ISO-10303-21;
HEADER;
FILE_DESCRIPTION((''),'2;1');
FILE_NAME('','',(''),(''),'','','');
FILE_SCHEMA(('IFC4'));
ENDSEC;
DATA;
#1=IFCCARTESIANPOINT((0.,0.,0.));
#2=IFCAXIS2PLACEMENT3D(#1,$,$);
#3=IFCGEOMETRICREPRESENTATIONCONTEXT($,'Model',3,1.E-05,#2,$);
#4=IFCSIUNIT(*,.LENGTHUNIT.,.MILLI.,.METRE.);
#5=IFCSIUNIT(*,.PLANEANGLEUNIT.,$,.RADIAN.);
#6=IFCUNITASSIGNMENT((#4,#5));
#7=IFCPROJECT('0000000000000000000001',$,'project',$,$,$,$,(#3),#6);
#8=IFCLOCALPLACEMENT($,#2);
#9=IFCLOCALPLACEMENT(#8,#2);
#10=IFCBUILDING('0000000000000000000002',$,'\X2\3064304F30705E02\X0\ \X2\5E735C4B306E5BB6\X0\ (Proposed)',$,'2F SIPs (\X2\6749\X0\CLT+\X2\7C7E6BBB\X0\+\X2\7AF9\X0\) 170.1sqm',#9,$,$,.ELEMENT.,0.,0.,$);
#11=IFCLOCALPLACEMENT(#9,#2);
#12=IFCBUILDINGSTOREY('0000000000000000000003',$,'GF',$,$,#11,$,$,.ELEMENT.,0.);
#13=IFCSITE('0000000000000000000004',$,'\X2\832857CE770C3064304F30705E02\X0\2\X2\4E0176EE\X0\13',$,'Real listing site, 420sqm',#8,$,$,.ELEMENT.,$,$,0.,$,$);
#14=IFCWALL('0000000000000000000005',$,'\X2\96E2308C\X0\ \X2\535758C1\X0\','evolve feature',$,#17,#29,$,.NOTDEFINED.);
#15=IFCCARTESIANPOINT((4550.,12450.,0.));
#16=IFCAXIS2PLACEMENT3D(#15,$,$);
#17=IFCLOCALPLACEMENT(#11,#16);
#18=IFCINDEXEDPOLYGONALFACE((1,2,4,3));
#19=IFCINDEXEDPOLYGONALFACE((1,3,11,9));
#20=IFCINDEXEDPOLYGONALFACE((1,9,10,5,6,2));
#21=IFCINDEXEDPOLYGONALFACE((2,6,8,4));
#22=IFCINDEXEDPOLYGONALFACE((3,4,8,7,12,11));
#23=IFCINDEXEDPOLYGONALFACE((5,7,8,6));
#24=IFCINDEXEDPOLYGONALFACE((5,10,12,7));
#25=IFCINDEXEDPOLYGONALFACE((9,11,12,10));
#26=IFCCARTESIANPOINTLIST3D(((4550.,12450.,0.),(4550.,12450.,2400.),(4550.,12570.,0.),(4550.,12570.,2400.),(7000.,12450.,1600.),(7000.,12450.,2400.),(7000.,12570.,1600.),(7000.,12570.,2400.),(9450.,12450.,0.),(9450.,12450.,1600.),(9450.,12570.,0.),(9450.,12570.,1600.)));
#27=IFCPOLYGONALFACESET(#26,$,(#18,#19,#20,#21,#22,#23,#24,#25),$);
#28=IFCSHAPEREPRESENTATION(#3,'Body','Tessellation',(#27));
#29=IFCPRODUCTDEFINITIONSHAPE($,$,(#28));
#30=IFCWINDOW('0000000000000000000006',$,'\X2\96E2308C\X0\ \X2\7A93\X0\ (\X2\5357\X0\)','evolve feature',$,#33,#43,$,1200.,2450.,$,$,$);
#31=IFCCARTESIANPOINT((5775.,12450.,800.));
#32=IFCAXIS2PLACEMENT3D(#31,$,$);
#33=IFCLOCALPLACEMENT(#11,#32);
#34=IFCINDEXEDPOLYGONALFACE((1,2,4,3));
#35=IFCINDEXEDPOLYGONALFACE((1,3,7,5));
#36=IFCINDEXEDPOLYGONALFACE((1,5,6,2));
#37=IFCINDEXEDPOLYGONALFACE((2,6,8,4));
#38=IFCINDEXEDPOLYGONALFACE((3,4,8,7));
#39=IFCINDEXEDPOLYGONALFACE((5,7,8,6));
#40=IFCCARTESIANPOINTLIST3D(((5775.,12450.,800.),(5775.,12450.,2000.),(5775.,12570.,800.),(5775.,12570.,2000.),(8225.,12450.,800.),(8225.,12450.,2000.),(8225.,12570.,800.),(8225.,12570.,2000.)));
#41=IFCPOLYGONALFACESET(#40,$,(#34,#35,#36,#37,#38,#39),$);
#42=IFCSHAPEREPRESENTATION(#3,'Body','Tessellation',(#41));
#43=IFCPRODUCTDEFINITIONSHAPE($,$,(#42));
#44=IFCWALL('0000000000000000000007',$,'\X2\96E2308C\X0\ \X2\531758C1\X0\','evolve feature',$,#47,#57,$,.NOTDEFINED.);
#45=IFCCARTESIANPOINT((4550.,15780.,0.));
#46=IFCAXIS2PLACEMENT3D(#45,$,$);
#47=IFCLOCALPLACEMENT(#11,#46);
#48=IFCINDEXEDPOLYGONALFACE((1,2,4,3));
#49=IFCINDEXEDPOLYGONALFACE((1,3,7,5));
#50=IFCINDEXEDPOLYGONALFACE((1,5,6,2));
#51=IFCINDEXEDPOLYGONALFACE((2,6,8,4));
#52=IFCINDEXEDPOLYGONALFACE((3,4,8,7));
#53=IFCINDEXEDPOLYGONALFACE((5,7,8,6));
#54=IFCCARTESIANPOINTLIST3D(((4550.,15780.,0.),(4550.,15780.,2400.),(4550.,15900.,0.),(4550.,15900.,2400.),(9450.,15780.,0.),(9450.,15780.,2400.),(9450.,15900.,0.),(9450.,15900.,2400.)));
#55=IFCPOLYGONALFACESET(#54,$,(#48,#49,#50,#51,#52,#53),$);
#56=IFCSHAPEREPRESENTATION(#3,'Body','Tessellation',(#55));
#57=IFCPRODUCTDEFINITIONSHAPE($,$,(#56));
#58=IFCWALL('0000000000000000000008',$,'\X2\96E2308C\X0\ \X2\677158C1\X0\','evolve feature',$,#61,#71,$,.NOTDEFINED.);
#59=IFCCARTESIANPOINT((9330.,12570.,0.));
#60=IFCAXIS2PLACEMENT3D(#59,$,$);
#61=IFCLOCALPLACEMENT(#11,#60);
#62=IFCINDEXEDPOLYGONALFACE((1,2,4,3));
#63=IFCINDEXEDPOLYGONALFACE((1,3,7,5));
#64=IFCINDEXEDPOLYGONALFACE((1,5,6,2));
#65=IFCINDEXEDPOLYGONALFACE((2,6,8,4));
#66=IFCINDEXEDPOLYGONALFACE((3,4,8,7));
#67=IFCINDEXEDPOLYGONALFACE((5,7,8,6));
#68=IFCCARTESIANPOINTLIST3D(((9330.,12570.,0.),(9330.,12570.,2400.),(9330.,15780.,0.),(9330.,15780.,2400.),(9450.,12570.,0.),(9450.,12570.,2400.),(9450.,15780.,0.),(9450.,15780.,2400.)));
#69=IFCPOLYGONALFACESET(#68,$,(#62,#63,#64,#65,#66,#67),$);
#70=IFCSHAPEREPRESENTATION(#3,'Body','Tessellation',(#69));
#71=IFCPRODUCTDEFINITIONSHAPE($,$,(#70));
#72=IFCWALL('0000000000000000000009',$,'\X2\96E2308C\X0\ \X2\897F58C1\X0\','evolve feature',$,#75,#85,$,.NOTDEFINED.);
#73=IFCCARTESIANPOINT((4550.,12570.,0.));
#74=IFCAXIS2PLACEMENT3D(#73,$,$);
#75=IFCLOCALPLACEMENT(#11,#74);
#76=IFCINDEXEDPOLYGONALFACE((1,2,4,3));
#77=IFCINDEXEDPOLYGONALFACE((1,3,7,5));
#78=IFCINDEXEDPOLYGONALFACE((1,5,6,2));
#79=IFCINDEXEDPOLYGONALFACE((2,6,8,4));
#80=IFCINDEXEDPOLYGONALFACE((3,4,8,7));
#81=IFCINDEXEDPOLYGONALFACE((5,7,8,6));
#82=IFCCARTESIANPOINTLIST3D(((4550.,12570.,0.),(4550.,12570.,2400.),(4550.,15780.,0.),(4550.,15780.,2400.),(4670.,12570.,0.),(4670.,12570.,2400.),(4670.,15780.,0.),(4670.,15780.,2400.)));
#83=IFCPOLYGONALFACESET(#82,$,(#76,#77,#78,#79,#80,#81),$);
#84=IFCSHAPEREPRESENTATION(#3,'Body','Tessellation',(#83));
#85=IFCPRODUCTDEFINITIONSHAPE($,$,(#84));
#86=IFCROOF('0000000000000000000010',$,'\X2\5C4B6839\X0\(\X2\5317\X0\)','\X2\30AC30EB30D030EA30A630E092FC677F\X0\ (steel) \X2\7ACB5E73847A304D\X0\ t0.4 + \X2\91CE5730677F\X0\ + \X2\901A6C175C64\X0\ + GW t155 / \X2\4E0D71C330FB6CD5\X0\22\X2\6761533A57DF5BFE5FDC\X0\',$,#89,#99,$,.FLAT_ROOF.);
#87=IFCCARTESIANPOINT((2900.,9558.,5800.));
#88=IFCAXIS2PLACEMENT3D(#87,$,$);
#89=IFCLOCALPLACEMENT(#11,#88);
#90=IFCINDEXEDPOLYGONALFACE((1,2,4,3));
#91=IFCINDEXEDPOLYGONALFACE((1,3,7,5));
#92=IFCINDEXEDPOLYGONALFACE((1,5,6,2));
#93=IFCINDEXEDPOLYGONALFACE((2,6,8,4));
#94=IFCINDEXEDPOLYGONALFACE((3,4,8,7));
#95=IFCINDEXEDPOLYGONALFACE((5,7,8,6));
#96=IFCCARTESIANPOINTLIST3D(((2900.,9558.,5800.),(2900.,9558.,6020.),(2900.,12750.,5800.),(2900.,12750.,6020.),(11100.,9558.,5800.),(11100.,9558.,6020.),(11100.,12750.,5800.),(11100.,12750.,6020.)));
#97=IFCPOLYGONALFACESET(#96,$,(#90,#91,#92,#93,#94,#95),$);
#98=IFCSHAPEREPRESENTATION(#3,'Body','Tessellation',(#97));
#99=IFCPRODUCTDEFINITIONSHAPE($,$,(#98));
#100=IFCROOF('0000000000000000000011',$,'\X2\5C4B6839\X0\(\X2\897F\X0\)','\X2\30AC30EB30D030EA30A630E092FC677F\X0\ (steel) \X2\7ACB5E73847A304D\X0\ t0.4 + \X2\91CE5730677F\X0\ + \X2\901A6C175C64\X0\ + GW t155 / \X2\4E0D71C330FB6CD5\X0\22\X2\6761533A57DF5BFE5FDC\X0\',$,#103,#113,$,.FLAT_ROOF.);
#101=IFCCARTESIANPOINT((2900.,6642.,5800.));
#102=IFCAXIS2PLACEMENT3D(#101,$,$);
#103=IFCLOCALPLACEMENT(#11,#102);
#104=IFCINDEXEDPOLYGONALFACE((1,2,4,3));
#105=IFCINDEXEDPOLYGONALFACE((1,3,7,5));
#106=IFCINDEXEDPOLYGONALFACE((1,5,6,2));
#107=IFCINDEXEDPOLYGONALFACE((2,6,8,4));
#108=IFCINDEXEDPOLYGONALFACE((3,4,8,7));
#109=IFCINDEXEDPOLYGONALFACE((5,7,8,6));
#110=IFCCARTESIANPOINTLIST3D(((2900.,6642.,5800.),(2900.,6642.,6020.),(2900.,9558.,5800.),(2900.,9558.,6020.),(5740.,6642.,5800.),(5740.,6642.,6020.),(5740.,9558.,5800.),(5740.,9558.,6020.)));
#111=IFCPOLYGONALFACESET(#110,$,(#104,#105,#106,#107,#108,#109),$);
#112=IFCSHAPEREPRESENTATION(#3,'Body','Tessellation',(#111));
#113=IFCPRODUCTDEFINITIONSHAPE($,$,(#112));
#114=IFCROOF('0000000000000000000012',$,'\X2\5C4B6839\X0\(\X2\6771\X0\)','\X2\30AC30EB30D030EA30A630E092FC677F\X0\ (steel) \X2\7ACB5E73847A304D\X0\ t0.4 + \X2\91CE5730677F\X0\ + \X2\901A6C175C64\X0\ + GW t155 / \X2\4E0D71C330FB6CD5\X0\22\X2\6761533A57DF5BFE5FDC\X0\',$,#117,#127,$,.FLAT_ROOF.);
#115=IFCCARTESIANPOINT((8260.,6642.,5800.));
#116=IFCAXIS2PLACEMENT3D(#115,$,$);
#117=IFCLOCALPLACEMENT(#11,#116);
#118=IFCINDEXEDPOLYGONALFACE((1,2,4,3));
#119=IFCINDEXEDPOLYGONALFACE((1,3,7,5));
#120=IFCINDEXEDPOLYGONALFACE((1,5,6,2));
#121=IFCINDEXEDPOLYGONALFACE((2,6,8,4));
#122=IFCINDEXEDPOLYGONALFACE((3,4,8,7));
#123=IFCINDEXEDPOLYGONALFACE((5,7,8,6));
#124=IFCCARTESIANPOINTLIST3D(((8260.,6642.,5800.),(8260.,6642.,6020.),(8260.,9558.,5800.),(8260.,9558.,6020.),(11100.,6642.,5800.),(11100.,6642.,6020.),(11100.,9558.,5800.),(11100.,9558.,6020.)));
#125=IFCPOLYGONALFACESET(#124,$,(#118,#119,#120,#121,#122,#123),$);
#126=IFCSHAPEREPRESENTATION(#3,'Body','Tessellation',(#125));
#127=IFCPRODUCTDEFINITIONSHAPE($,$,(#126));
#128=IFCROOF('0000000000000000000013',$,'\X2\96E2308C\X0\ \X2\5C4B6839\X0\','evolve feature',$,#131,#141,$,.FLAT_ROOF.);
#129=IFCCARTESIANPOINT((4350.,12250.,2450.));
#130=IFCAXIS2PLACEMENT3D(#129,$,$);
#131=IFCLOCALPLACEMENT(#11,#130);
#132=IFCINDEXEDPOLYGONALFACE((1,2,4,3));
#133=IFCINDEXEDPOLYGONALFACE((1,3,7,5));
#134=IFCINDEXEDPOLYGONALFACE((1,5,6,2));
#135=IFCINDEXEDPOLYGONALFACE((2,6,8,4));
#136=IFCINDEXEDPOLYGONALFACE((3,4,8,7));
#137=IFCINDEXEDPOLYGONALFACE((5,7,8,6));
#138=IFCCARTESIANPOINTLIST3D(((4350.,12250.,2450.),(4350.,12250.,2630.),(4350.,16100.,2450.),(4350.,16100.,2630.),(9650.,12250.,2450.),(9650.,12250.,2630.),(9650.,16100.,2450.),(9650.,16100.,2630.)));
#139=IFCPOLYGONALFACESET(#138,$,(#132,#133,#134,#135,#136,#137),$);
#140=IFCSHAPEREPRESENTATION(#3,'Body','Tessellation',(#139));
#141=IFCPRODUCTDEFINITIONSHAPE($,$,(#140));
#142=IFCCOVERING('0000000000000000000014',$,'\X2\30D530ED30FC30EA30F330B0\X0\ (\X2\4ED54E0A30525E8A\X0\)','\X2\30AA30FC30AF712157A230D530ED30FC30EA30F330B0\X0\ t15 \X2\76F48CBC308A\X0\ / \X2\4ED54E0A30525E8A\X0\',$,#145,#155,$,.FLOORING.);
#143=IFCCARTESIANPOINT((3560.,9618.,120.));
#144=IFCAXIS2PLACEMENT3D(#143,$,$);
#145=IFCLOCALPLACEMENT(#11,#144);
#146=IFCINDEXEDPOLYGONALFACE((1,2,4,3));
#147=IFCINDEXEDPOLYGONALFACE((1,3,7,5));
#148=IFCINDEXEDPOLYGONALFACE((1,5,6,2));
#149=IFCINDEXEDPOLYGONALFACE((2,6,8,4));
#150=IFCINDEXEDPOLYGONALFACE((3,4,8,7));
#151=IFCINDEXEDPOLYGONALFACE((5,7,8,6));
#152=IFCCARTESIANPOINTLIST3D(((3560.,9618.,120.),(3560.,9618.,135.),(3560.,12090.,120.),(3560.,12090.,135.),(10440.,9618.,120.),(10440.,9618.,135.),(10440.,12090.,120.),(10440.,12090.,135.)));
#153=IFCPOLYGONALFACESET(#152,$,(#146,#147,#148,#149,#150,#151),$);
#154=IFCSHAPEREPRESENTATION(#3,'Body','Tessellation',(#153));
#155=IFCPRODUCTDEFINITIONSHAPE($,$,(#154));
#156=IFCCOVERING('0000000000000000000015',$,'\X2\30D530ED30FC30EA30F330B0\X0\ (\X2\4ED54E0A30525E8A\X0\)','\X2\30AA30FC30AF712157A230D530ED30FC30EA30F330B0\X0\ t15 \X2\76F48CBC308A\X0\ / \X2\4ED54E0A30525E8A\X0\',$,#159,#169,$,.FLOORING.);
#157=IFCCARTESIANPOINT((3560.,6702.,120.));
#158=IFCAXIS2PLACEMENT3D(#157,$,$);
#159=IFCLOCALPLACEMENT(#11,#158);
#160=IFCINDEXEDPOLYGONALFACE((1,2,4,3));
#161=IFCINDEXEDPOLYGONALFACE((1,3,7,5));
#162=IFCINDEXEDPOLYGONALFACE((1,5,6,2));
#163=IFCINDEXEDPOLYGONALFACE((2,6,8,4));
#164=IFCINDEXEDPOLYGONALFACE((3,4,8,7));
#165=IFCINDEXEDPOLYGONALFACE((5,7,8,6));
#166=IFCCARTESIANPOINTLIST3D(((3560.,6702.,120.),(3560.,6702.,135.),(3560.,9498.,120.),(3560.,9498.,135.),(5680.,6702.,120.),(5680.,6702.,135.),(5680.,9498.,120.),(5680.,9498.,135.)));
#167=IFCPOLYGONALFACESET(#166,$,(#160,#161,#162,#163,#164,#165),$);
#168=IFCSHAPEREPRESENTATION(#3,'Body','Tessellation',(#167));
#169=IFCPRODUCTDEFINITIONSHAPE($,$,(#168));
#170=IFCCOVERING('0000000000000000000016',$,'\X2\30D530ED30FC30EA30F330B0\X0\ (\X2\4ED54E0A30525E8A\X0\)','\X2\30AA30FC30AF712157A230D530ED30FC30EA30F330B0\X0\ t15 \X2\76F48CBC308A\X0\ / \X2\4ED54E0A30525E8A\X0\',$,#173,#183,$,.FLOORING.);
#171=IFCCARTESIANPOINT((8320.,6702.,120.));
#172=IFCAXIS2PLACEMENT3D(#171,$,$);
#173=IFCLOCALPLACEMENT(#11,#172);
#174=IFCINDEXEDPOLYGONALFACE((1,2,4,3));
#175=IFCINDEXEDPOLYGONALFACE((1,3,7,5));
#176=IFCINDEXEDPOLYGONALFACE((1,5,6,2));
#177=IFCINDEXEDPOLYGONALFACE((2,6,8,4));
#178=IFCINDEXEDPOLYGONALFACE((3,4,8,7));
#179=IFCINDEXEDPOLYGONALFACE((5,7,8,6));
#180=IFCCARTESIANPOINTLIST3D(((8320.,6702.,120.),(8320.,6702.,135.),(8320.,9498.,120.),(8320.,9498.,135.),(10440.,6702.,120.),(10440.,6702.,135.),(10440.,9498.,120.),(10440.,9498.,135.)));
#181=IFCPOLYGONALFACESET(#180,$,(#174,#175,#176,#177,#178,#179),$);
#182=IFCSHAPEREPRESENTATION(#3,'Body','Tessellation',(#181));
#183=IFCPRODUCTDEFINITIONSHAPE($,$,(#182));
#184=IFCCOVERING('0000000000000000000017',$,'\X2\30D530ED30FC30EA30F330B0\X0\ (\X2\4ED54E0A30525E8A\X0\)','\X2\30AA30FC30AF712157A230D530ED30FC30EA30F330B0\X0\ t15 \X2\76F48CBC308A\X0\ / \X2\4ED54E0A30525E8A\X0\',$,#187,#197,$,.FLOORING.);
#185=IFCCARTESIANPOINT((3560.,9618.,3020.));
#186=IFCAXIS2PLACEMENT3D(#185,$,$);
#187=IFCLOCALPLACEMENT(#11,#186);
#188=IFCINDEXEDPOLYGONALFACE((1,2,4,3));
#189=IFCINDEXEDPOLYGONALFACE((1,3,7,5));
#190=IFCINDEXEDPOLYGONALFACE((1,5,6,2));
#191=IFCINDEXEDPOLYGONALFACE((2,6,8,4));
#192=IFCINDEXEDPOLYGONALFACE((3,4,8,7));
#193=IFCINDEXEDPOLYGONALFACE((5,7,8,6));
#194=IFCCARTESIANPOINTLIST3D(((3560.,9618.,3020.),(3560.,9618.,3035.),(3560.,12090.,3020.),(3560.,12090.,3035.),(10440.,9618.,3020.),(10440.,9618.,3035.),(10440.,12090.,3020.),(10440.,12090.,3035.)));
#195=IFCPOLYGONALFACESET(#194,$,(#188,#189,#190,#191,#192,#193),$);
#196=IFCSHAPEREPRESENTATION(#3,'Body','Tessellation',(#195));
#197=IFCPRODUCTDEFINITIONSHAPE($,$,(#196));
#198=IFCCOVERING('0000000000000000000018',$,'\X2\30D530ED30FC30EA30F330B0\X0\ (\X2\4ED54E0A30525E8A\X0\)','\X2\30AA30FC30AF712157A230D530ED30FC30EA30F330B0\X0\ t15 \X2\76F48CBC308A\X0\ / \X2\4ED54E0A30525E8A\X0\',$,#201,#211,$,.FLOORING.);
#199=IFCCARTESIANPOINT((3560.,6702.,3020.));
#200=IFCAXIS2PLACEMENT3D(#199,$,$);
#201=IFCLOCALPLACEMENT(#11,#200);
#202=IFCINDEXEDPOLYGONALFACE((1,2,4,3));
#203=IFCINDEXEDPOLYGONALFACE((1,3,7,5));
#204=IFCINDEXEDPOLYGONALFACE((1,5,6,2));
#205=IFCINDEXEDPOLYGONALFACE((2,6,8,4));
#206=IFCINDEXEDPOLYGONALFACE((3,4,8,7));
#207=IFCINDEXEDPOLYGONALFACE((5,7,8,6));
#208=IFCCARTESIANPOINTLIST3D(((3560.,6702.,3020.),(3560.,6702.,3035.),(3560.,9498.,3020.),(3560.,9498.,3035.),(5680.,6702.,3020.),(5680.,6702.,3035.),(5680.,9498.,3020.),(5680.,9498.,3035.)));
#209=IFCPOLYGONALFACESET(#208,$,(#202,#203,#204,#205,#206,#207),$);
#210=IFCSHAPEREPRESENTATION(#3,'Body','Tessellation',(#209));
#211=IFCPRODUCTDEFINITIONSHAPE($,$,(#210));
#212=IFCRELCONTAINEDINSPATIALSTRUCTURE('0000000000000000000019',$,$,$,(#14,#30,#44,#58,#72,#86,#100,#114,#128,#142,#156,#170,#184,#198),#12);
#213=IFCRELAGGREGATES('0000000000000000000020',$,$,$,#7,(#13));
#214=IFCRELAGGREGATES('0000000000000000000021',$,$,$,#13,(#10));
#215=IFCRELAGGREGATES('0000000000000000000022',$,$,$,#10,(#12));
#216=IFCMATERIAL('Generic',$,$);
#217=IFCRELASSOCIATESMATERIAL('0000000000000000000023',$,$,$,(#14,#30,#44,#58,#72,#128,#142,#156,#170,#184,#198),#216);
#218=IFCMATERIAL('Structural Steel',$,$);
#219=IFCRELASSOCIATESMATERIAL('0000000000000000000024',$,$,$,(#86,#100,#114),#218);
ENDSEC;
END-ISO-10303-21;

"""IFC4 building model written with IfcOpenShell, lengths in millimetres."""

from ifc_helpers import new_model, si_unit, frame, frame_2d, origin, place, context, project, spatial, rectangle, extrude, material, element, fill, save


model = new_model("IFC4")

# Units and contexts
model_context = context("Model", 3, precision=1e-05, world=origin())
ifc_project = project(units=[si_unit("LENGTHUNIT", "METRE", prefix="MILLI"), si_unit("PLANEANGLEUNIT", "RADIAN")], contexts=[model_context])

# Site, building, storey
site_placement = place(None, origin())
site = spatial("IfcSite", under=ifc_project, at=site_placement, Name="茨城県つくば市2丁目13", ObjectType="Real listing site, 420sqm", CompositionType="ELEMENT", RefElevation=0.0)
building_placement = place(site_placement, origin())
building = spatial("IfcBuilding", under=site, at=building_placement, Name="つくば市 平屋の家 (Proposed)", ObjectType="2F SIPs (杉CLT+籾殻+竹) 170.1sqm", CompositionType="ELEMENT", ElevationOfRefHeight=0.0, ElevationOfTerrain=0.0)
storey_placement = place(building_placement, origin())
storey = spatial("IfcBuildingStorey", under=building, at=storey_placement, Name="GF", CompositionType="ELEMENT", Elevation=0.0)

# Shared definitions
ifc_material_1 = material(Name="Generic")

# Wall, opening, window
wall_1_placement = place(storey_placement, frame((4550.0, 12450.0, 0.0)))
wall_1 = element("IfcWall", 1, at=wall_1_placement, inside=storey, material=ifc_material_1, Name="離れ 南壁", Description="evolve feature", PredefinedType="NOTDEFINED", context=model_context, shape_type="SweptSolid", body=[
    extrude(rectangle(XDim=4900.0, YDim=120.0, at=frame_2d((2450.0, 60.0))), frame((4550.0, 12450.0, 0.0)), (0.0, 0.0, 1.0), 2400.0),
])
opening_1_placement = place(storey_placement, frame((5775.0, 12450.0, 800.0)))
opening_1 = element("IfcOpeningElement", 2, at=opening_1_placement, cuts=wall_1, PredefinedType="NOTDEFINED", context=model_context, shape_type="SweptSolid", body=[
    extrude(rectangle(XDim=2450.0, YDim=120.0, at=frame_2d((1225.0, 60.0))), frame((5775.0, 12450.0, 800.0)), (0.0, 0.0, 1.0), 1200.0),
])
window_1_placement = place(storey_placement, frame((5775.0, 12450.0, 800.0)))
window_1 = element("IfcWindow", 3, at=window_1_placement, inside=storey, material=ifc_material_1, Name="離れ 窓 (南)", Description="evolve feature", OverallHeight=1200.0, OverallWidth=2450.0, context=model_context, shape_type="SweptSolid", body=[
    extrude(rectangle(XDim=2450.0, YDim=120.0, at=frame_2d((1225.0, 60.0))), frame((5775.0, 12450.0, 800.0)), (0.0, 0.0, 1.0), 1200.0),
])
fill(opening_1, window_1)

# Walls
wall_2_placement = place(storey_placement, frame((4550.0, 15780.0, 0.0)))
element("IfcWall", 4, at=wall_2_placement, inside=storey, material=ifc_material_1, Name="離れ 北壁", Description="evolve feature", PredefinedType="NOTDEFINED", context=model_context, shape_type="SweptSolid", body=[
    extrude(rectangle(XDim=4900.0, YDim=120.0, at=frame_2d((2450.0, 60.0))), frame((4550.0, 15780.0, 0.0)), (0.0, 0.0, 1.0), 2400.0),
])
wall_3_placement = place(storey_placement, frame((9330.0, 12570.0, 0.0)))
element("IfcWall", 5, at=wall_3_placement, inside=storey, material=ifc_material_1, Name="離れ 東壁", Description="evolve feature", PredefinedType="NOTDEFINED", context=model_context, shape_type="SweptSolid", body=[
    extrude(rectangle(XDim=120.0, YDim=3210.0, at=frame_2d((60.0, 1605.0))), frame((9330.0, 12570.0, 0.0)), (0.0, 0.0, 1.0), 2400.0),
])
wall_4_placement = place(storey_placement, frame((4550.0, 12570.0, 0.0)))
element("IfcWall", 6, at=wall_4_placement, inside=storey, material=ifc_material_1, Name="離れ 西壁", Description="evolve feature", PredefinedType="NOTDEFINED", context=model_context, shape_type="SweptSolid", body=[
    extrude(rectangle(XDim=120.0, YDim=3210.0, at=frame_2d((60.0, 1605.0))), frame((4550.0, 12570.0, 0.0)), (0.0, 0.0, 1.0), 2400.0),
])

# Roofs
ifc_material_2 = material(Name="Structural Steel")
for number, where, name in (
    (7, (2900.0, 9558.0, 5800.0), "屋根(北)"),
):
    element("IfcRoof", number, at=place(storey_placement, frame(where)), inside=storey, material=ifc_material_2, Name=name, Description="ガルバリウム鋼板 (steel) 立平葺き t0.4 + 野地板 + 通気層 + GW t155 / 不燃・法22条区域対応", PredefinedType="FLAT_ROOF", context=model_context, shape_type="SweptSolid", body=[
        extrude(rectangle(XDim=8200.0, YDim=3192.0, at=frame_2d((4100.0, 1596.0))), frame((2900.0, 9558.0, 5800.0)), (0.0, 0.0, 1.0), 220.0),
    ])
roof_1_placement = place(storey_placement, frame((2900.0, 6642.0, 5800.0)))
element("IfcRoof", 8, at=roof_1_placement, inside=storey, material=ifc_material_2, Name="屋根(西)", Description="ガルバリウム鋼板 (steel) 立平葺き t0.4 + 野地板 + 通気層 + GW t155 / 不燃・法22条区域対応", PredefinedType="FLAT_ROOF", context=model_context, shape_type="SweptSolid", body=[
    extrude(rectangle(XDim=2840.0, YDim=2916.0, at=frame_2d((1420.0, 1458.0))), frame((2900.0, 6642.0, 5800.0)), (0.0, 0.0, 1.0), 220.0),
])
roof_2_placement = place(storey_placement, frame((8260.0, 6642.0, 5800.0)))
element("IfcRoof", 9, at=roof_2_placement, inside=storey, material=ifc_material_2, Name="屋根(東)", Description="ガルバリウム鋼板 (steel) 立平葺き t0.4 + 野地板 + 通気層 + GW t155 / 不燃・法22条区域対応", PredefinedType="FLAT_ROOF", context=model_context, shape_type="SweptSolid", body=[
    extrude(rectangle(XDim=2840.0, YDim=2916.0, at=frame_2d((1420.0, 1458.0))), frame((8260.0, 6642.0, 5800.0)), (0.0, 0.0, 1.0), 220.0),
])
roof_3_placement = place(storey_placement, frame((4350.0, 12250.0, 2450.0)))
element("IfcRoof", 10, at=roof_3_placement, inside=storey, material=ifc_material_1, Name="離れ 屋根", Description="evolve feature", PredefinedType="FLAT_ROOF", context=model_context, shape_type="SweptSolid", body=[
    extrude(rectangle(XDim=5300.0, YDim=3850.0, at=frame_2d((2650.0, 1925.0))), frame((4350.0, 12250.0, 2450.0)), (0.0, 0.0, 1.0), 180.0),
])

# Coverings
covering_1_placement = place(storey_placement, frame((3560.0, 9618.0, 120.0)))
element("IfcCovering", 11, at=covering_1_placement, inside=storey, material=ifc_material_1, Name="フローリング (仕上げ床)", Description="オーク無垢フローリング t15 直貼り / 仕上げ床", PredefinedType="FLOORING", context=model_context, shape_type="SweptSolid", body=[
    extrude(rectangle(XDim=6880.0, YDim=2472.0, at=frame_2d((3440.0, 1236.0))), frame((3560.0, 9618.0, 120.0)), (0.0, 0.0, 1.0), 15.0),
])
covering_2_placement = place(storey_placement, frame((3560.0, 6702.0, 120.0)))
element("IfcCovering", 12, at=covering_2_placement, inside=storey, material=ifc_material_1, Name="フローリング (仕上げ床)", Description="オーク無垢フローリング t15 直貼り / 仕上げ床", PredefinedType="FLOORING", context=model_context, shape_type="SweptSolid", body=[
    extrude(rectangle(XDim=2120.0, YDim=2796.0, at=frame_2d((1060.0, 1398.0))), frame((3560.0, 6702.0, 120.0)), (0.0, 0.0, 1.0), 15.0),
])
covering_3_placement = place(storey_placement, frame((8320.0, 6702.0, 120.0)))
element("IfcCovering", 13, at=covering_3_placement, inside=storey, material=ifc_material_1, Name="フローリング (仕上げ床)", Description="オーク無垢フローリング t15 直貼り / 仕上げ床", PredefinedType="FLOORING", context=model_context, shape_type="SweptSolid", body=[
    extrude(rectangle(XDim=2120.0, YDim=2796.0, at=frame_2d((1060.0, 1398.0))), frame((8320.0, 6702.0, 120.0)), (0.0, 0.0, 1.0), 15.0),
])
covering_4_placement = place(storey_placement, frame((3560.0, 9618.0, 3020.0)))
element("IfcCovering", 14, at=covering_4_placement, inside=storey, material=ifc_material_1, Name="フローリング (仕上げ床)", Description="オーク無垢フローリング t15 直貼り / 仕上げ床", PredefinedType="FLOORING", context=model_context, shape_type="SweptSolid", body=[
    extrude(rectangle(XDim=6880.0, YDim=2472.0, at=frame_2d((3440.0, 1236.0))), frame((3560.0, 9618.0, 3020.0)), (0.0, 0.0, 1.0), 15.0),
])
covering_5_placement = place(storey_placement, frame((3560.0, 6702.0, 3020.0)))
element("IfcCovering", 15, at=covering_5_placement, inside=storey, material=ifc_material_1, Name="フローリング (仕上げ床)", Description="オーク無垢フローリング t15 直貼り / 仕上げ床", PredefinedType="FLOORING", context=model_context, shape_type="SweptSolid", body=[
    extrude(rectangle(XDim=2120.0, YDim=2796.0, at=frame_2d((1060.0, 1398.0))), frame((3560.0, 6702.0, 3020.0)), (0.0, 0.0, 1.0), 15.0),
])

save(model, "model.ifc")
